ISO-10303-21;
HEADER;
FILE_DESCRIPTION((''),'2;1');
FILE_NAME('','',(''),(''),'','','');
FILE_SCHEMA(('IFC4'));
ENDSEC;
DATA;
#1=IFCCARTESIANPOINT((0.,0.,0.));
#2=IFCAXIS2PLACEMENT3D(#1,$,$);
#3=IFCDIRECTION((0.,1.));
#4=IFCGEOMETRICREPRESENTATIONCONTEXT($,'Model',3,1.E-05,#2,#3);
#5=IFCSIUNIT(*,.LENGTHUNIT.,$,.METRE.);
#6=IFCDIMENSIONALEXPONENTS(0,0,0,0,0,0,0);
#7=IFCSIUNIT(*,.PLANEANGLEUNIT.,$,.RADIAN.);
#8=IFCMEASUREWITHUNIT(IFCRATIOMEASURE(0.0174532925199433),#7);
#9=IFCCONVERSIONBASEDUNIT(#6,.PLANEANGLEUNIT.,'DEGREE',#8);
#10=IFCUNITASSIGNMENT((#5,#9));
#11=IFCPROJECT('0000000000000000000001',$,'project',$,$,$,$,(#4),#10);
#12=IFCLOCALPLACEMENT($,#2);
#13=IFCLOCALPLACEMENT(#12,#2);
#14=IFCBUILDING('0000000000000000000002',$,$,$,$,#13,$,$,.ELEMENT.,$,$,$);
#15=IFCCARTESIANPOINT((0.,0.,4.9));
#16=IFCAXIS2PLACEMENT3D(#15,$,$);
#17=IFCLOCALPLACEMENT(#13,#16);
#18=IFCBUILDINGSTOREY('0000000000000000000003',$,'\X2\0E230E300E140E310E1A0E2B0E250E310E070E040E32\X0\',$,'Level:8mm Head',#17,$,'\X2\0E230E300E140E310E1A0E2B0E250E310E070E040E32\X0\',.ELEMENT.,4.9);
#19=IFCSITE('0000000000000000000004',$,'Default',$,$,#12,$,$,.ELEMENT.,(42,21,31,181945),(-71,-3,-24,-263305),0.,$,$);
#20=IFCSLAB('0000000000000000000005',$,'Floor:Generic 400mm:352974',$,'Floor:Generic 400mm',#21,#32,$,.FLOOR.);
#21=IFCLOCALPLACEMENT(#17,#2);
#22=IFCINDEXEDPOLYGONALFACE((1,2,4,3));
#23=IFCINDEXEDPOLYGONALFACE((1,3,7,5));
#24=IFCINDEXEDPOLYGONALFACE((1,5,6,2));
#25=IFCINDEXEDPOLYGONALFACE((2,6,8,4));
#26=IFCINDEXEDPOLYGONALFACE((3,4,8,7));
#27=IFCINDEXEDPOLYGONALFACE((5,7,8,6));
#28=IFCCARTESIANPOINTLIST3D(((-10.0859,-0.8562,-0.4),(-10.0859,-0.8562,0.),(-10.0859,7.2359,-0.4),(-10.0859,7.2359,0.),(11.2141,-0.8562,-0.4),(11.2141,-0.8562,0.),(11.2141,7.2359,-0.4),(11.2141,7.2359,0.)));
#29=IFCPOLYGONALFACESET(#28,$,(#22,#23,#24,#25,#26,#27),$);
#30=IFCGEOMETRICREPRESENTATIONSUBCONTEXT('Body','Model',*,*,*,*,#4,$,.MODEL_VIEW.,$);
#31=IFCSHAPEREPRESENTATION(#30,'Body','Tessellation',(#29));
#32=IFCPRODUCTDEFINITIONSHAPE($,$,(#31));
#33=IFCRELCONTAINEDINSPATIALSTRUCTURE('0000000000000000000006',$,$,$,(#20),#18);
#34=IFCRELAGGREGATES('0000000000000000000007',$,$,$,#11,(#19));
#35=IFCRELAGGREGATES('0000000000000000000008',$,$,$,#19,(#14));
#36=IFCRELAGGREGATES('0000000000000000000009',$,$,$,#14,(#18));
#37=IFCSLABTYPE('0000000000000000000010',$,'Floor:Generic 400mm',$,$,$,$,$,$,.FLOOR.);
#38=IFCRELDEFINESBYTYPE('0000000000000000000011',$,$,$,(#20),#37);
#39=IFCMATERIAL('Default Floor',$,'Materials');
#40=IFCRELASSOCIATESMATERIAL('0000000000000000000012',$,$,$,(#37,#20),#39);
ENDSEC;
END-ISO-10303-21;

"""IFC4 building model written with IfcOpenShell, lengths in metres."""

from ifc_helpers import new_model, entity, si_unit, converted_unit, direction, frame, origin, place, context, subcontext, project, spatial, indexed_curve, outline, extrude, material, type_object, element, save


model = new_model("IFC4")

# Units and contexts
model_context = context("Model", 3, precision=1e-05, world=origin(), true_north=direction((0.0, 1.0)))
body_context = subcontext(model_context, "Body", "Model", "MODEL_VIEW")
ifc_project = project(units=[si_unit("LENGTHUNIT", "METRE"), converted_unit("PLANEANGLEUNIT", "DEGREE", entity("IfcRatioMeasure", 0.0174532925199433), si_unit("PLANEANGLEUNIT", "RADIAN"), dimensions=[0, 0, 0, 0, 0, 0, 0])], contexts=[model_context])

# Site, building, storey
site_placement = place(None, origin())
site = spatial("IfcSite", under=ifc_project, at=site_placement, Name="Default", CompositionType="ELEMENT", RefLatitude=(42, 21, 31, 181945), RefLongitude=(-71, -3, -24, -263305), RefElevation=0.0)
building_placement = place(site_placement, origin())
building = spatial("IfcBuilding", under=site, at=building_placement, CompositionType="ELEMENT")
storey_placement = place(building_placement, frame((0.0, 0.0, 4.9)))
storey = spatial("IfcBuildingStorey", under=building, at=storey_placement, Name="ระดับหลังคา", ObjectType="Level:8mm Head", LongName="ระดับหลังคา", CompositionType="ELEMENT", Elevation=4.9)

# Slab
ifc_material = material(Name="Default Floor", Category="Materials")
slab_type = type_object("IfcSlabType", Name="Floor:Generic 400mm", PredefinedType="FLOOR", material=ifc_material)
slab_placement = place(storey_placement, origin())
element("IfcSlab", 1, at=slab_placement, inside=storey, type_object=slab_type, material=ifc_material, Name="Floor:Generic 400mm:352974", ObjectType="Floor:Generic 400mm", PredefinedType="FLOOR", context=body_context, shape_type="SweptSolid", body=[
    extrude(outline(indexed_curve([(-4.046, -10.65), (4.0461, -10.65), (4.046, 10.65), (-4.0461, 10.65), (-4.046, -10.65)], self_intersect=False)), frame((0.5641, 3.1898, 0.0), z_axis=(0.0, 0.0, -1.0), x_axis=(0.0, 1.0, 0.0)), (0.0, 0.0, 1.0), 0.4),
])

save(model, "model.ifc")
